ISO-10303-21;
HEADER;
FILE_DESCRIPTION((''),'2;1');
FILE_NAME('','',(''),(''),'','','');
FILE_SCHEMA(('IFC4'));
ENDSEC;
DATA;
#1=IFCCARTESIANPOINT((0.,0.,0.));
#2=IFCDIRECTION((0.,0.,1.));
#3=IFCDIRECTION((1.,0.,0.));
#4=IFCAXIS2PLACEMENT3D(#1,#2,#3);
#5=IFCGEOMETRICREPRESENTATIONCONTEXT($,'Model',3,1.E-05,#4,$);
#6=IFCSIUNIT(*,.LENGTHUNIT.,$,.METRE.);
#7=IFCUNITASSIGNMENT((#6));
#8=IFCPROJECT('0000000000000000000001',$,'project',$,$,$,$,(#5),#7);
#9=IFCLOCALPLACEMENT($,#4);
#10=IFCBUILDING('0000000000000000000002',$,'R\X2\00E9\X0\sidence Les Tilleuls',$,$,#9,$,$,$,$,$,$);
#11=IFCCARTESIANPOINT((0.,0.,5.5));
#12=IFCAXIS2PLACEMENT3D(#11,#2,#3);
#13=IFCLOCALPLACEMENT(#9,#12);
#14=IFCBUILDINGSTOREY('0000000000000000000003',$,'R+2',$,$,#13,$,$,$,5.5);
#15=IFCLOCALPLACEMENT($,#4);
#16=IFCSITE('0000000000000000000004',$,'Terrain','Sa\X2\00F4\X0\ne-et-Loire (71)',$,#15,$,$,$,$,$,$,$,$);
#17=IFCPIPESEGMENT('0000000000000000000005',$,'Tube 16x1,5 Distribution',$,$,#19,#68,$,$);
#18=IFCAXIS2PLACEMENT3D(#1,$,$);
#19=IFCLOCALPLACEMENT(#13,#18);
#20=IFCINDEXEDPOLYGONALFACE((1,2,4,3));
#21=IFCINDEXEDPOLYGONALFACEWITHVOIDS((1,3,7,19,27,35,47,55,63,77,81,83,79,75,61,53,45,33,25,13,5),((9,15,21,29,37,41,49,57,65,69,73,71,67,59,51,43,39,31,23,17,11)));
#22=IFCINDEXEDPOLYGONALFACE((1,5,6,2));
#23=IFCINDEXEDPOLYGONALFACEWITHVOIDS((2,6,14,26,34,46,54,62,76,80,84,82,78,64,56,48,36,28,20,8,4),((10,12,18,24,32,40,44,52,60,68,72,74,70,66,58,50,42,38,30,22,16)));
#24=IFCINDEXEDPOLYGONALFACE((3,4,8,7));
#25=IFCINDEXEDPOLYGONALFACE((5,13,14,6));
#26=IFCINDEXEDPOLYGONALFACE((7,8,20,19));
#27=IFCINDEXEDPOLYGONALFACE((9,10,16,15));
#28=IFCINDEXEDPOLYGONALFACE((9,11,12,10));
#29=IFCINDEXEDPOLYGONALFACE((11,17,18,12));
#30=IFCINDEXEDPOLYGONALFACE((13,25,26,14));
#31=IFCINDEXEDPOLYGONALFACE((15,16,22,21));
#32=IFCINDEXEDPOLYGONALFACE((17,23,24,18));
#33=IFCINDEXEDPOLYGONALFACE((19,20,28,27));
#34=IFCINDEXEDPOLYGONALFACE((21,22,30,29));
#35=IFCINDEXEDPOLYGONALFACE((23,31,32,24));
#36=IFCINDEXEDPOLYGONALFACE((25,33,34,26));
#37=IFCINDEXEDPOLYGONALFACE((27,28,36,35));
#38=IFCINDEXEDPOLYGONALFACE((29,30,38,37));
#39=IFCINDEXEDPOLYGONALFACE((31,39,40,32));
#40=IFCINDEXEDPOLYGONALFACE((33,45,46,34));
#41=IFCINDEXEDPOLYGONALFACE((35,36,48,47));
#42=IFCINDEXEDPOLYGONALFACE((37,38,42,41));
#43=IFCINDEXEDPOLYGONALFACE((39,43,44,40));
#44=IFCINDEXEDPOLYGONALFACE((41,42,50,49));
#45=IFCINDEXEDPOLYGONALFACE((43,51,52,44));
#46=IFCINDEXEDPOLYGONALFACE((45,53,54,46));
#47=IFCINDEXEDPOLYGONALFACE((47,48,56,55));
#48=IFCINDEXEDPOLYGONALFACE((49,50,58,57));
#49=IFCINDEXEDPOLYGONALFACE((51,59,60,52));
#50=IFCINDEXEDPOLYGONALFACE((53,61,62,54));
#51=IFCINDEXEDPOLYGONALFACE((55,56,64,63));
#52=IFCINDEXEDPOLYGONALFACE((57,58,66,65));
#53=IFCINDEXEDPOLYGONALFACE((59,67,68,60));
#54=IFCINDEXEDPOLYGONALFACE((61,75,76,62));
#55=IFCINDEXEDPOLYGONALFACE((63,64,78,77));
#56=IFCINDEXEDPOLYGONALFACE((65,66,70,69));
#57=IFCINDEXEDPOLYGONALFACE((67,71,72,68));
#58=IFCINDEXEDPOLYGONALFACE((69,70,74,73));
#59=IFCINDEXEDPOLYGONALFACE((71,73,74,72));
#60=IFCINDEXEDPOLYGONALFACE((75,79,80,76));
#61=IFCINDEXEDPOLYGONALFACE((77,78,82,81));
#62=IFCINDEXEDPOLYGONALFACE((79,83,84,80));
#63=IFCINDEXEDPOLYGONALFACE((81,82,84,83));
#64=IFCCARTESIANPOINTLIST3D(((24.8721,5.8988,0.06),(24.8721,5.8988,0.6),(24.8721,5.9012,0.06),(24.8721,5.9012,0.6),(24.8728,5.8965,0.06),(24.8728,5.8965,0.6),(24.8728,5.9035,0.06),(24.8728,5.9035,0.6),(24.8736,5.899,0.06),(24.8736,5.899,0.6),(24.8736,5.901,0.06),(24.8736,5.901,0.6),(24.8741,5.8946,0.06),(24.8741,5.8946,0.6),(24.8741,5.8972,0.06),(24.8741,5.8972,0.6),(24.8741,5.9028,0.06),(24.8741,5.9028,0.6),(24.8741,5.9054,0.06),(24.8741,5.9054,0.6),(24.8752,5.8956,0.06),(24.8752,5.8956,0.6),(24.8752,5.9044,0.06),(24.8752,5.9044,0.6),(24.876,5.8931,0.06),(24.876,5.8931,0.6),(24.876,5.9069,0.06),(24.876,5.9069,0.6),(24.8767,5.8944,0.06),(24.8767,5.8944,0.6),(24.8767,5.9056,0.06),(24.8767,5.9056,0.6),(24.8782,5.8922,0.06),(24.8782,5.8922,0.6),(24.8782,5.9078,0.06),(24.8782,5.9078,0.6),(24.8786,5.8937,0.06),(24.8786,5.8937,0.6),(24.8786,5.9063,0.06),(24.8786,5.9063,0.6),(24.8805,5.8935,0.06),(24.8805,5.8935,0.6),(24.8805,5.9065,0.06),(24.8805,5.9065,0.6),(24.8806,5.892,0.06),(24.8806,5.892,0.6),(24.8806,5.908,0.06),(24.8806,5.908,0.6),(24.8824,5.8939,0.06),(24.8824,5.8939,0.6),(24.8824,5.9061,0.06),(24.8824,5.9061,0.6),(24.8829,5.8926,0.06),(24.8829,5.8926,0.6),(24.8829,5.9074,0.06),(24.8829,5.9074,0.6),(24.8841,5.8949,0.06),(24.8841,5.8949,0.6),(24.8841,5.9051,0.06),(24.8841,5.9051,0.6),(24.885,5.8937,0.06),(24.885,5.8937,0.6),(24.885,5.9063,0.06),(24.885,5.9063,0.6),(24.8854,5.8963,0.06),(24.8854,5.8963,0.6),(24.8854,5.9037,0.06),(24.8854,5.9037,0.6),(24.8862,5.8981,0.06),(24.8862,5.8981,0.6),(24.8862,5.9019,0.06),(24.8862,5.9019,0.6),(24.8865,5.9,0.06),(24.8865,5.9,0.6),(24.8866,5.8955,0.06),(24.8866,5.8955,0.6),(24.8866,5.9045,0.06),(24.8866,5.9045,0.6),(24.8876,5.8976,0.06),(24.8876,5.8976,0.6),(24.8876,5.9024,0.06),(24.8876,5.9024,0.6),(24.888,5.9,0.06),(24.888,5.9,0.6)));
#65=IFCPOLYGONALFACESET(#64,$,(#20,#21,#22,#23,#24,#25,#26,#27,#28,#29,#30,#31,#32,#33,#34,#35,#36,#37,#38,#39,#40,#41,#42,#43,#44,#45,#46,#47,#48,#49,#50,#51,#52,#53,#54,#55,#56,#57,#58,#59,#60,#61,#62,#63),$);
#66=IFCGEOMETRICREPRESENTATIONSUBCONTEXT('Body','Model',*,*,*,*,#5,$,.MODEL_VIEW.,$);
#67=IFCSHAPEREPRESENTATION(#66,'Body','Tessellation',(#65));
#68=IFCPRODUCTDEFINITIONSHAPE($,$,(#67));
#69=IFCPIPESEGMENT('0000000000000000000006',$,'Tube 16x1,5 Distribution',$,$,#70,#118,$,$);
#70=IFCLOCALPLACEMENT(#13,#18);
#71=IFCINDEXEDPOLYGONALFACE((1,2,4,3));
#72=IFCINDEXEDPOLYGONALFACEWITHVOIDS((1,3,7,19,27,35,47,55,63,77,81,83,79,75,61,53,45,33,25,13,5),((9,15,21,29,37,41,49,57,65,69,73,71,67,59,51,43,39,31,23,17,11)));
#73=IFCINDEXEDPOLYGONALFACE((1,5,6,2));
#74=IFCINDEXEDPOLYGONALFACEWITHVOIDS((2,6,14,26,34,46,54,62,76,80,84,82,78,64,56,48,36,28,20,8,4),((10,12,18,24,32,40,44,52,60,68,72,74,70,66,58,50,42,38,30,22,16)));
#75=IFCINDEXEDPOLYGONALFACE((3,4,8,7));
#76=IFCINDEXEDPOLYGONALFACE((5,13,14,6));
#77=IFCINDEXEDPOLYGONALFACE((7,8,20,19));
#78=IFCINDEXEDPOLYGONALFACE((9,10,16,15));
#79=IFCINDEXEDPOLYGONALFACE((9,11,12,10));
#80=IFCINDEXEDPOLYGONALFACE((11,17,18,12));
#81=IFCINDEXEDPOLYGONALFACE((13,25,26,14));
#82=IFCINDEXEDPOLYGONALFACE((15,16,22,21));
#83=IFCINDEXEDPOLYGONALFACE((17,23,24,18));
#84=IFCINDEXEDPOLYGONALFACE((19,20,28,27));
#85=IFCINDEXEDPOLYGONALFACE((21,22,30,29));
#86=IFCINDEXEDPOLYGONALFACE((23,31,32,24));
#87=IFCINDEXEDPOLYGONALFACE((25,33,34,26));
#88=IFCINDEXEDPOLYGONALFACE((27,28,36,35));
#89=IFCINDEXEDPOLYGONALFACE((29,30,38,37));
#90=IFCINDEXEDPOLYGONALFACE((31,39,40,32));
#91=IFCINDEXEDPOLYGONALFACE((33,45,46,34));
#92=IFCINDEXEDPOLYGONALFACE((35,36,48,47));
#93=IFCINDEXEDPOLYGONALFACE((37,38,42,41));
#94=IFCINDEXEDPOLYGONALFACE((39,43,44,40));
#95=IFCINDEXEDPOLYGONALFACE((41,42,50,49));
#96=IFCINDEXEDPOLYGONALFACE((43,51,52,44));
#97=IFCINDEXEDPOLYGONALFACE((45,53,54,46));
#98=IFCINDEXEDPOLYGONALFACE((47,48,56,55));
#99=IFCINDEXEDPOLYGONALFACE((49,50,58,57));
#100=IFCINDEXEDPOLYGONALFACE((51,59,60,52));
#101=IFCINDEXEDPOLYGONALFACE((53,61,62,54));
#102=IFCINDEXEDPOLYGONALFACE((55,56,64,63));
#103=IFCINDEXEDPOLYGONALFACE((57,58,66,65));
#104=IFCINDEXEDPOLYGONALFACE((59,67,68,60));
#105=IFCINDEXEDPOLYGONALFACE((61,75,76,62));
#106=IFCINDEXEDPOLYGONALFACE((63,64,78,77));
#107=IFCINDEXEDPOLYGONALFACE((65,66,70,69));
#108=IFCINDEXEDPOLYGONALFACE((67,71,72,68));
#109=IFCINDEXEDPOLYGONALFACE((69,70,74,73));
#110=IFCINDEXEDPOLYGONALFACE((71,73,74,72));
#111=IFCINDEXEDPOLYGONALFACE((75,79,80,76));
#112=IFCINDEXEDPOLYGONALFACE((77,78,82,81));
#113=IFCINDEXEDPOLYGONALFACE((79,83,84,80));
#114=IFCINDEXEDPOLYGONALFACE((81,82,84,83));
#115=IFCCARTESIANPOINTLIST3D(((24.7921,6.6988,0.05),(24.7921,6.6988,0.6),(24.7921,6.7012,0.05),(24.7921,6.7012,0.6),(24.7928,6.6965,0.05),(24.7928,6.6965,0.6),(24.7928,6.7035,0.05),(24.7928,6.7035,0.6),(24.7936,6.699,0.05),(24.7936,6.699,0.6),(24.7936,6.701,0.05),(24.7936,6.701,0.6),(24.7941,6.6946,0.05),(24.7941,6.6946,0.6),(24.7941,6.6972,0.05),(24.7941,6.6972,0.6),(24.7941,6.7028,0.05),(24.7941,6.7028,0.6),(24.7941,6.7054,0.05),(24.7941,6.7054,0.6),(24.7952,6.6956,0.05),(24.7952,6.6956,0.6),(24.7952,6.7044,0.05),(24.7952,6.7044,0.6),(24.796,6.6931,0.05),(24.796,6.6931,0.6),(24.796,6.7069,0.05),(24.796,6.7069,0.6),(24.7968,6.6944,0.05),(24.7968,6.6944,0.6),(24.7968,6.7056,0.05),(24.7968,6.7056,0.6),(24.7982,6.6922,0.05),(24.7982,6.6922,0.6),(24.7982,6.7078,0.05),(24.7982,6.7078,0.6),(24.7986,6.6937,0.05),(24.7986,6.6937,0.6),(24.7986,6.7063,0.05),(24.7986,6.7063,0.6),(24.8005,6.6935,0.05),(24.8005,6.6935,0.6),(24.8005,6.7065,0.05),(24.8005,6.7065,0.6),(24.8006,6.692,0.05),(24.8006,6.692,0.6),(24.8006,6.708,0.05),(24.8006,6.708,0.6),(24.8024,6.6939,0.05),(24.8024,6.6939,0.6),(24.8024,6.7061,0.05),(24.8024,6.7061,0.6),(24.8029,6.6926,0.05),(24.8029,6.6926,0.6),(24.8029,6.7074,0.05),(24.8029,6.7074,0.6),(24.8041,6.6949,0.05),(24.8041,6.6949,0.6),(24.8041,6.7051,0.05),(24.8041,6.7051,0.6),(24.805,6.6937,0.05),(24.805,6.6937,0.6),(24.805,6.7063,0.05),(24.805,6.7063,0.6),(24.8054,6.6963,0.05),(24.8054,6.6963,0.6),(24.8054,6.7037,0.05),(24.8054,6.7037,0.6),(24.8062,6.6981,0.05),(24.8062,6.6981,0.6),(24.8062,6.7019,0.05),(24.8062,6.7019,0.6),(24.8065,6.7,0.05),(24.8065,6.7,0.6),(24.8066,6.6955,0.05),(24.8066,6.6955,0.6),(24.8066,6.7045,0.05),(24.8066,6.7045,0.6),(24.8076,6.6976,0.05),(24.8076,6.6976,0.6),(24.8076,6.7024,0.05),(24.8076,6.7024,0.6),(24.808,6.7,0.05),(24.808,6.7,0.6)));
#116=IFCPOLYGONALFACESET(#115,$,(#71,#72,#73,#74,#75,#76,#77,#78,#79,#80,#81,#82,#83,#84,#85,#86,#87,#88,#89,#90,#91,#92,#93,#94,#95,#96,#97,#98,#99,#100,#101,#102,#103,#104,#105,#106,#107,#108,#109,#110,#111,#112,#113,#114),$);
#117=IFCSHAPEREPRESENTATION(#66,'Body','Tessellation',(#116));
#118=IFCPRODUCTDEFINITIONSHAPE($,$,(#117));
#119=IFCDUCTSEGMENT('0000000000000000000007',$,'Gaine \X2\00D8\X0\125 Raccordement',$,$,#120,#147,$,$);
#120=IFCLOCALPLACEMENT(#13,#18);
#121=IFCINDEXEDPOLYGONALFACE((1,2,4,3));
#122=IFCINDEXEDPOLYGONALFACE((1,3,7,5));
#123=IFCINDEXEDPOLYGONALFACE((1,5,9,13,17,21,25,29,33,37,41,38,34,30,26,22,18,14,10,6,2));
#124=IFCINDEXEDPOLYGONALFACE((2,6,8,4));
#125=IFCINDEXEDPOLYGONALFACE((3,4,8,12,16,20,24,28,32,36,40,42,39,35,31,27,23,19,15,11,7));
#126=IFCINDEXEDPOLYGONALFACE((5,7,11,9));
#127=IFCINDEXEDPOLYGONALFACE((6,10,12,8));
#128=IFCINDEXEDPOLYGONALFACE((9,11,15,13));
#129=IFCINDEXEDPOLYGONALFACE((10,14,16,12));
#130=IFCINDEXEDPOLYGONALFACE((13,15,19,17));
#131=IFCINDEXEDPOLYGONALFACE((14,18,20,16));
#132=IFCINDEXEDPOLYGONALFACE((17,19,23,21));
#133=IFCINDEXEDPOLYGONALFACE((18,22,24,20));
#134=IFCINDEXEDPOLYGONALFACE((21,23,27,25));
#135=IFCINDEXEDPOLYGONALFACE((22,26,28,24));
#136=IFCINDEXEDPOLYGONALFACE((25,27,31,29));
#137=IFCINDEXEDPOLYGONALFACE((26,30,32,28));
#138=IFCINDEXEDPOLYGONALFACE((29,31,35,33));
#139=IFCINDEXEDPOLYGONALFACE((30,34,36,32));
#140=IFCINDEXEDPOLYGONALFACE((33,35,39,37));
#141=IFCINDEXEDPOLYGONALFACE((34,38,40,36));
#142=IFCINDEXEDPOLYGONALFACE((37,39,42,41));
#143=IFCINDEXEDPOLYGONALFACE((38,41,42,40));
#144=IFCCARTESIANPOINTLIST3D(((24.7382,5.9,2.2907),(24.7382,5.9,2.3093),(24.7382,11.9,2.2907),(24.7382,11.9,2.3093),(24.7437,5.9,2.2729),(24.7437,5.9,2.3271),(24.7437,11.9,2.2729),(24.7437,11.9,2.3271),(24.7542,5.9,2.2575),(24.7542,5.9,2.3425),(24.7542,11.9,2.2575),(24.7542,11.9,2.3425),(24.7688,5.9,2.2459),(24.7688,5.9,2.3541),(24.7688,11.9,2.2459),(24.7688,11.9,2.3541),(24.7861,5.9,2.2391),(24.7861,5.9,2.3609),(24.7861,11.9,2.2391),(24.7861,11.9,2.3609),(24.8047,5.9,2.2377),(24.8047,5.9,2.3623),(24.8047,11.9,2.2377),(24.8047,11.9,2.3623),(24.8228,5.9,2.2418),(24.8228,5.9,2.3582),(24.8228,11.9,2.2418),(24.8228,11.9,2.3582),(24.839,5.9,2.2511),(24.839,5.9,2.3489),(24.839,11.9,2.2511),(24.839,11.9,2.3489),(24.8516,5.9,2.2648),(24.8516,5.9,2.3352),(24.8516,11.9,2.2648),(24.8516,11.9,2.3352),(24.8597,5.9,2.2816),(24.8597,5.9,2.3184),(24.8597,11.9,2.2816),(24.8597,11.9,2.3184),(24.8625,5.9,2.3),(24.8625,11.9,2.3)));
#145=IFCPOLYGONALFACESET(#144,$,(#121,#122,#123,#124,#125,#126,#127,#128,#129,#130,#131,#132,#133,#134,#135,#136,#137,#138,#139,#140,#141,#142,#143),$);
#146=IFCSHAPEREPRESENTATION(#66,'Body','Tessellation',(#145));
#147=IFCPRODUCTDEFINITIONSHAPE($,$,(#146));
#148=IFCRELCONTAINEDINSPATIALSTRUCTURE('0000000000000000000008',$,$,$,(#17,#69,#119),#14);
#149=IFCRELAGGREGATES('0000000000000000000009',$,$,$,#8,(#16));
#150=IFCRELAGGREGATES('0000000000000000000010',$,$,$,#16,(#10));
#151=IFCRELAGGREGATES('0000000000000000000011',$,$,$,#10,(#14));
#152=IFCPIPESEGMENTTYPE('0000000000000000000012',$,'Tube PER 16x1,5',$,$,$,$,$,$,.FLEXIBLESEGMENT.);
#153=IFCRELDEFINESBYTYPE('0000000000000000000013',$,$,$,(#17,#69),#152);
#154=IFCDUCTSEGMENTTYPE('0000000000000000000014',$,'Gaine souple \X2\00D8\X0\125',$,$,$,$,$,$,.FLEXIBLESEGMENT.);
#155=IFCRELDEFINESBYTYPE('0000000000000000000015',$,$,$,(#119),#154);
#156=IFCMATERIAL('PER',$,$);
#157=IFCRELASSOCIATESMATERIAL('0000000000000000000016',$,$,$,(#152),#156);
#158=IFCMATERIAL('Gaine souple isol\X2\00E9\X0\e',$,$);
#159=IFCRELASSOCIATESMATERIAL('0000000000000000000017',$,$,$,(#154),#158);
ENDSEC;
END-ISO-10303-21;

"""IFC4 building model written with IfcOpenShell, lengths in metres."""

from ifc_helpers import new_model, si_unit, frame, origin_with_axes, place, context, subcontext, project, spatial, circle, hollow_circle, extrude, material, type_object, element, save


model = new_model("IFC4")

# Units and contexts
model_context = context("Model", 3, precision=1e-05, world=origin_with_axes())
body_context = subcontext(model_context, "Body", "Model", "MODEL_VIEW")
ifc_project = project(units=[si_unit("LENGTHUNIT", "METRE")], contexts=[model_context])

# Site, building, storey
site_placement = place(None, origin_with_axes())
site = spatial("IfcSite", under=ifc_project, at=site_placement, Name="Terrain", Description="Saône-et-Loire (71)")
building_placement = place(None, origin_with_axes())
building = spatial("IfcBuilding", under=site, at=building_placement, Name="Résidence Les Tilleuls")
storey_placement = place(building_placement, frame((0.0, 0.0, 5.5), z_axis=(0.0, 0.0, 1.0), x_axis=(1.0, 0.0, 0.0)))
storey = spatial("IfcBuildingStorey", under=building, at=storey_placement, Name="R+2", Elevation=5.5)

# Pipe segments
ifc_material_1 = material(Name="PER")
pipe_segment_type_1 = type_object("IfcPipeSegmentType", Name="Tube PER 16x1,5", PredefinedType="FLEXIBLESEGMENT", material=ifc_material_1)
pipe_segment_1_placement = place(storey_placement, frame((24.88, 5.9, 0.06), z_axis=(0.0, 0.0, 1.0), x_axis=(1.0, 0.0, 0.0)))
element("IfcPipeSegment", 1, at=pipe_segment_1_placement, inside=storey, type_object=pipe_segment_type_1, Name="Tube 16x1,5 Distribution", context=body_context, shape_type="SweptSolid", body=[
    extrude(hollow_circle(Radius=0.008, WallThickness=0.0015), origin_with_axes(), (0.0, 0.0, 1.0), 0.54),
])
pipe_segment_2_placement = place(storey_placement, frame((24.8, 6.7, 0.05), z_axis=(0.0, 0.0, 1.0), x_axis=(1.0, 0.0, 0.0)))
element("IfcPipeSegment", 2, at=pipe_segment_2_placement, inside=storey, type_object=pipe_segment_type_1, Name="Tube 16x1,5 Distribution", context=body_context, shape_type="SweptSolid", body=[
    extrude(hollow_circle(Radius=0.008, WallThickness=0.0015), origin_with_axes(), (0.0, 0.0, 1.0), 0.55),
])

# Duct segment
ifc_material_2 = material(Name="Gaine souple isolée")
duct_segment_type = type_object("IfcDuctSegmentType", Name="Gaine souple Ø125", PredefinedType="FLEXIBLESEGMENT", material=ifc_material_2)
duct_segment_placement = place(storey_placement, frame((24.8, 5.9, 2.3), z_axis=(0.0, 1.0, 0.0), x_axis=(1.0, 0.0, 0.0)))
element("IfcDuctSegment", 3, at=duct_segment_placement, inside=storey, type_object=duct_segment_type, Name="Gaine Ø125 Raccordement", context=body_context, shape_type="SweptSolid", body=[
    extrude(circle(Radius=0.0625), origin_with_axes(), (0.0, 0.0, 1.0), 6.0),
])

save(model, "model.ifc")
